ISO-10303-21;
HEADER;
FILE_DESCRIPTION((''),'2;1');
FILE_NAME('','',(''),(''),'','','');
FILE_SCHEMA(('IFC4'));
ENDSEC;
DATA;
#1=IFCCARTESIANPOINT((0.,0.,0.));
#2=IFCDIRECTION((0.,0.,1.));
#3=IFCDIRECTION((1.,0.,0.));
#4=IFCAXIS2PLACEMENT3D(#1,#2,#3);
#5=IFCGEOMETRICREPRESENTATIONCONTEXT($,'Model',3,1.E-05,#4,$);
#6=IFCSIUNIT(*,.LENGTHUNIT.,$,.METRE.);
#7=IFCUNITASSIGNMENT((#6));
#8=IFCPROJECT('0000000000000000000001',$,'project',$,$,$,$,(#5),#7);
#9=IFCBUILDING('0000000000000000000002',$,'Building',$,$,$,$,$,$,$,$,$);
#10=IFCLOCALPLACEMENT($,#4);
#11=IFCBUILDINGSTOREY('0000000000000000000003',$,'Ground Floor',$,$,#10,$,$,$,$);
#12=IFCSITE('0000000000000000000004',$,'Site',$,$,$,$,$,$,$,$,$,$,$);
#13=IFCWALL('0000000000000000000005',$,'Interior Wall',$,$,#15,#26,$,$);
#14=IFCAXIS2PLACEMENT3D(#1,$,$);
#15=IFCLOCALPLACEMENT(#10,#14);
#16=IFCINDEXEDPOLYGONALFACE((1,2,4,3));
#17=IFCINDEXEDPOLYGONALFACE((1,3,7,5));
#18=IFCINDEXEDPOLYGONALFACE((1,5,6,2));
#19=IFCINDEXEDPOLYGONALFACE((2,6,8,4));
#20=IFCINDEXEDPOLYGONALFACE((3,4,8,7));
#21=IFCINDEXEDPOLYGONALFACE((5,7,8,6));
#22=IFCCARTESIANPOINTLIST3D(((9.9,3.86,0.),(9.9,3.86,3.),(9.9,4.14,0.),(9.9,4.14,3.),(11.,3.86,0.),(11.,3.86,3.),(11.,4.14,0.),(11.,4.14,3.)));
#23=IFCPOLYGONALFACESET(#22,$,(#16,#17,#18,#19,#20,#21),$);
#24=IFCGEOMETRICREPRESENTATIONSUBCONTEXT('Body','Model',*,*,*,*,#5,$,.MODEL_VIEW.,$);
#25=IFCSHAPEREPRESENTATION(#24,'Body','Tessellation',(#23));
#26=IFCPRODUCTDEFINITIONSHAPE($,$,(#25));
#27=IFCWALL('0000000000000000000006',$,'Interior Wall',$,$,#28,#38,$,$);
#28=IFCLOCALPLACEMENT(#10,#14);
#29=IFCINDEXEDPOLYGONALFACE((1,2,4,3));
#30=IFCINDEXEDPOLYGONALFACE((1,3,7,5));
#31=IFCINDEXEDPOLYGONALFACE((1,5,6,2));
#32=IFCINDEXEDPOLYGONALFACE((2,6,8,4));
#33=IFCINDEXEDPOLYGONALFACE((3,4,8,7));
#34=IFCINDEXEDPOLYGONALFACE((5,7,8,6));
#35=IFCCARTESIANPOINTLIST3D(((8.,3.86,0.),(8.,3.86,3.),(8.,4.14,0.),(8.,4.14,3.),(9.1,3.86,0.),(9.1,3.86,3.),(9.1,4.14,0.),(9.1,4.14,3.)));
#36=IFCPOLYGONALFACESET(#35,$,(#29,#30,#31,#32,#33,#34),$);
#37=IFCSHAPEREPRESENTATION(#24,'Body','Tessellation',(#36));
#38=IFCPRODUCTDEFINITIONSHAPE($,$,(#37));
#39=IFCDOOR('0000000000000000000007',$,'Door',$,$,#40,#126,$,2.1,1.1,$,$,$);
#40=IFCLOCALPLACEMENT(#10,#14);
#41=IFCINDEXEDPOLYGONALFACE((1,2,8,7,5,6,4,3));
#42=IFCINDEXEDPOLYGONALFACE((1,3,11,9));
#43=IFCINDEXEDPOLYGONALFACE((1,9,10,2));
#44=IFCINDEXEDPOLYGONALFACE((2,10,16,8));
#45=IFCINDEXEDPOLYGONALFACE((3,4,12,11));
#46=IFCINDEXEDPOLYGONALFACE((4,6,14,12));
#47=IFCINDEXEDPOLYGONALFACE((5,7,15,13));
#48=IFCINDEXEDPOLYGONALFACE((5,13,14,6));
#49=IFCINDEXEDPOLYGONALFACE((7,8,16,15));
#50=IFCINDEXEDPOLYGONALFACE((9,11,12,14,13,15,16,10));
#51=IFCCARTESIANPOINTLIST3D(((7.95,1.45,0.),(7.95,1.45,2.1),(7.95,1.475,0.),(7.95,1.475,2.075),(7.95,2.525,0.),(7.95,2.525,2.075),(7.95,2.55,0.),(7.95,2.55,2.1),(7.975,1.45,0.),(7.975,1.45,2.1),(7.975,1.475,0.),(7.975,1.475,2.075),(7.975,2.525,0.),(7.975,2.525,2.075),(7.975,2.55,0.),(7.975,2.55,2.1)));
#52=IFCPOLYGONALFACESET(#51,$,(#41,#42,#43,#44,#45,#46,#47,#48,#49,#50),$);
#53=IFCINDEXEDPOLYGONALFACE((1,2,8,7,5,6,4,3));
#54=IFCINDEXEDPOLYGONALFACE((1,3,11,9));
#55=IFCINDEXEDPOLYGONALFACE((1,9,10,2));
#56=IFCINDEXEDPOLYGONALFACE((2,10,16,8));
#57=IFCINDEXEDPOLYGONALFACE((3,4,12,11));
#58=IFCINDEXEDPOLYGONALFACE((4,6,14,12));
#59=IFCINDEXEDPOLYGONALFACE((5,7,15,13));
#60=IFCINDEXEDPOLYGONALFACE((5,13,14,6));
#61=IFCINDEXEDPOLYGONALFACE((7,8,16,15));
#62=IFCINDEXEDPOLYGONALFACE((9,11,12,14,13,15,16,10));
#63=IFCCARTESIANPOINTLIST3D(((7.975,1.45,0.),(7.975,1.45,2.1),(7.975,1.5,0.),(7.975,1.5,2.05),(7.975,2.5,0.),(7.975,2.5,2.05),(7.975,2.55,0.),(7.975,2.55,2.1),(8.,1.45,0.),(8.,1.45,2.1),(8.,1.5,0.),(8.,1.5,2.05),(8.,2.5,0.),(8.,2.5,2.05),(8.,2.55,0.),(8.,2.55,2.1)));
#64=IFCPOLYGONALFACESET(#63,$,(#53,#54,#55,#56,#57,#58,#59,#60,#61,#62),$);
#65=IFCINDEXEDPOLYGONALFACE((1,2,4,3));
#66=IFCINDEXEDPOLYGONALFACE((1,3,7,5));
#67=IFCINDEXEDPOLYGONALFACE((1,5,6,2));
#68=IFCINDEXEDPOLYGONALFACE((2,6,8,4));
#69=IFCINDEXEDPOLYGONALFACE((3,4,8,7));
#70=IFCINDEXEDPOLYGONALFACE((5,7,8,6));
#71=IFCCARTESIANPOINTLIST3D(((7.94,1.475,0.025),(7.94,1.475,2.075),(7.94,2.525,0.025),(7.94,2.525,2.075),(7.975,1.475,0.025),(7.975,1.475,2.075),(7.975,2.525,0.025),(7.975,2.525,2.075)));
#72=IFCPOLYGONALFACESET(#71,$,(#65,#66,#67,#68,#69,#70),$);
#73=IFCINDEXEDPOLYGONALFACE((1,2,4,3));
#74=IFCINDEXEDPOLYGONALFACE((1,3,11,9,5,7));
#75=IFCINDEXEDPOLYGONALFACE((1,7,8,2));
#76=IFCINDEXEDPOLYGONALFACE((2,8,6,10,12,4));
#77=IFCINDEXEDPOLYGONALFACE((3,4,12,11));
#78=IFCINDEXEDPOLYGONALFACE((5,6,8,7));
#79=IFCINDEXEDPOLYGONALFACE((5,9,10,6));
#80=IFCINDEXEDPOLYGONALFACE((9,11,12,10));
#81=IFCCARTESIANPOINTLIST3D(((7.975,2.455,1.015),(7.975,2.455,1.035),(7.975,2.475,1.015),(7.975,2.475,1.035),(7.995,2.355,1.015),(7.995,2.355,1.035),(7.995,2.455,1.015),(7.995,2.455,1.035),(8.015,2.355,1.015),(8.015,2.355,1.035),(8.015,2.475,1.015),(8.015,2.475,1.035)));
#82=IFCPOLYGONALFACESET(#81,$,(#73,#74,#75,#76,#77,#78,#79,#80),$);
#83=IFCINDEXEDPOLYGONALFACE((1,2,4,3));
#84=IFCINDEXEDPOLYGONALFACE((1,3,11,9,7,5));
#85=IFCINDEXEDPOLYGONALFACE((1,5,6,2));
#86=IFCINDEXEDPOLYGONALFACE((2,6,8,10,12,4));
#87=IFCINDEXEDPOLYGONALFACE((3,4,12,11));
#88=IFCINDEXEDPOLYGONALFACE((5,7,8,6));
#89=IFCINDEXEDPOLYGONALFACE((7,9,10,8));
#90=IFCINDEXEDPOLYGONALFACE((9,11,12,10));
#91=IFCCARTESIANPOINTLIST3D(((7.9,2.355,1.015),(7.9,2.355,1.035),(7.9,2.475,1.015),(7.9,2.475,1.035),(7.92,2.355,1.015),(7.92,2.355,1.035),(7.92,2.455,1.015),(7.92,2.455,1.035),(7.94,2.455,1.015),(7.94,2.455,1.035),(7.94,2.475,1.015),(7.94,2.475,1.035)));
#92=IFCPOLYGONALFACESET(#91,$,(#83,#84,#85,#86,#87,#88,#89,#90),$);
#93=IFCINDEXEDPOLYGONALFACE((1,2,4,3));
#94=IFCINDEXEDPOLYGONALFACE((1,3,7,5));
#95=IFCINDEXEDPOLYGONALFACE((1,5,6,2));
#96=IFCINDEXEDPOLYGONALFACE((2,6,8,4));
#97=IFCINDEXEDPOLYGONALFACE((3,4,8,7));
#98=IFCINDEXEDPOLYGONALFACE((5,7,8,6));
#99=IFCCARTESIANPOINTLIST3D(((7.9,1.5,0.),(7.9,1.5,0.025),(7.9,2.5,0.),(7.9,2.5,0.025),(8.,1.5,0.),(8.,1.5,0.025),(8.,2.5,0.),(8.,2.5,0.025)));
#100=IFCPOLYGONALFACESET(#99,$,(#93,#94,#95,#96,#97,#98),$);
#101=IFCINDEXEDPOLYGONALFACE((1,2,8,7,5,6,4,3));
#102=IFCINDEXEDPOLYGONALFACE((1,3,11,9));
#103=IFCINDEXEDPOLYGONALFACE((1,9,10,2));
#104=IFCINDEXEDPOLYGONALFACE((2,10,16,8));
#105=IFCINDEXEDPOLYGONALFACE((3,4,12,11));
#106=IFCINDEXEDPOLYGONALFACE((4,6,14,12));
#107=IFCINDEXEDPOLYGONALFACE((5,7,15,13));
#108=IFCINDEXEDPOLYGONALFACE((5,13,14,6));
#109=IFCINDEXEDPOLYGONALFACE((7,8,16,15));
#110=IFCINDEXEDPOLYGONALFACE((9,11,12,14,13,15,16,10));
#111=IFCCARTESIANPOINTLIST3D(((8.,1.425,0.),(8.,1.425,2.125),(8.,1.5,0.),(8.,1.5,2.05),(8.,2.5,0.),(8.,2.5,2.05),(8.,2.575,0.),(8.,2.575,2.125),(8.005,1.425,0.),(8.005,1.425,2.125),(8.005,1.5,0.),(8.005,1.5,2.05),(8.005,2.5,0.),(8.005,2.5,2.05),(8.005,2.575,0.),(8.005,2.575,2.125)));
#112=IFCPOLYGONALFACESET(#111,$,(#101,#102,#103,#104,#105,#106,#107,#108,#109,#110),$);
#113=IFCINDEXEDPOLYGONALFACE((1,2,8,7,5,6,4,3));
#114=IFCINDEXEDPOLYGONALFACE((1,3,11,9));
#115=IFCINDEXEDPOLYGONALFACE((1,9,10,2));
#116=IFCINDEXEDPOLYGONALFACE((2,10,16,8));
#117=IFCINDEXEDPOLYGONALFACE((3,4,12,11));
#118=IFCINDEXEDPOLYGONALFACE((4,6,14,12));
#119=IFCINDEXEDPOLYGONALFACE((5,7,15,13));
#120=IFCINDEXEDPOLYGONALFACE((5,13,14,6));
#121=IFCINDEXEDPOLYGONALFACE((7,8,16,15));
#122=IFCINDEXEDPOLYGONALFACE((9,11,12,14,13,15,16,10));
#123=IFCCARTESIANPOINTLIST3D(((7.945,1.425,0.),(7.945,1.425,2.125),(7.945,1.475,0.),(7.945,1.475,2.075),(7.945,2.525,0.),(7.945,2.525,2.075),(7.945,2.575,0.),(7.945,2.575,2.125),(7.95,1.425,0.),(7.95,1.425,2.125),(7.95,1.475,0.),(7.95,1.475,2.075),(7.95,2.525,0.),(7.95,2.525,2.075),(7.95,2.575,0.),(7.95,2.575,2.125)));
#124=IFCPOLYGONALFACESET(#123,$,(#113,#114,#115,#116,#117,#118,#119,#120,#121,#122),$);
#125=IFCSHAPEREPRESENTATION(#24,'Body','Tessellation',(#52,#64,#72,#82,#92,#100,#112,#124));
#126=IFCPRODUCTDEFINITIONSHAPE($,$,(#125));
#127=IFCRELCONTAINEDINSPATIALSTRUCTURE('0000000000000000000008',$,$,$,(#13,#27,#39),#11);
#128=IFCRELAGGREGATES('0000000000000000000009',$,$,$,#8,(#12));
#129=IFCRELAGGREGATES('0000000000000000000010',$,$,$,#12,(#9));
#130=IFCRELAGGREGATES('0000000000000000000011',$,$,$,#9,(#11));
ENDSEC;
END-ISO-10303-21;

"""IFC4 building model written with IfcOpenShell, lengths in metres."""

from ifc_helpers import new_model, si_unit, frame, origin_with_axes, place, context, subcontext, project, spatial, line, indexed_curve, outline, extrude, element, save


model = new_model("IFC4")

# Units and contexts
model_context = context("Model", 3, precision=1e-05, world=origin_with_axes())
body_context = subcontext(model_context, "Body", "Model", "MODEL_VIEW")
ifc_project = project(units=[si_unit("LENGTHUNIT", "METRE")], contexts=[model_context])

# Site, building, storey
site = spatial("IfcSite", under=ifc_project, Name="Site")
building = spatial("IfcBuilding", under=site, Name="Building")
storey_placement = place(None, origin_with_axes())
storey = spatial("IfcBuildingStorey", under=building, at=storey_placement, Name="Ground Floor")

# Walls
for number, where, z_axis, x_axis, name in (
    (1, (11.0, 4.0, 0.0), (0.0, 0.0, 1.0), (-1.0, 0.0, 0.0), "Interior Wall"),
    (2, (9.1, 4.0, 0.0), (0.0, 0.0, 1.0), (-1.0, 0.0, 0.0), "Interior Wall"),
):
    element("IfcWall", number, at=place(storey_placement, frame(where, z_axis=z_axis, x_axis=x_axis)), inside=storey, Name=name, context=body_context, shape_type="SweptSolid", body=[
        extrude(outline(indexed_curve([(0.0, 0.0), (0.0, 0.28), (1.1, 0.28), (1.1, 0.0), (0.0, 0.0)], self_intersect=False)), frame((0.0, -0.14, 0.0), z_axis=(0.0, 0.0, 1.0), x_axis=(1.0, 0.0, 0.0)), (0.0, 0.0, 1.0), 3.0),
    ])

# Door
door_1_placement = place(storey_placement, frame((8.0, 1.45, 0.0), z_axis=(0.0, 0.0, 1.0), x_axis=(0.0, 1.0, 0.0)))
element("IfcDoor", 3, at=door_1_placement, inside=storey, Name="Door", OverallHeight=2.1, OverallWidth=1.1, context=body_context, shape_type="SweptSolid", body=[
    extrude(outline(indexed_curve([(0.0, 0.0), (0.0, 2.1), (1.1, 2.1), (1.1, 0.0), (1.075, 0.0), (1.075, 2.075), (0.025, 2.075), (0.025, 0.0)], segments=[line(1, 2, 3, 4, 5, 6, 7, 8, 1)])), frame((0.0, 0.025, 0.0), z_axis=(0.0, -1.0, 0.0), x_axis=(1.0, 0.0, 0.0)), (0.0, 0.0, -1.0), 0.025),
    extrude(outline(indexed_curve([(0.0, 0.0), (0.0, 2.1), (1.1, 2.1), (1.1, 0.0), (1.05, 0.0), (1.05, 2.05), (0.05, 2.05), (0.05, 0.0)], segments=[line(1, 2, 3, 4, 5, 6, 7, 8, 1)])), frame((0.0, 0.0, 0.0), z_axis=(0.0, -1.0, 0.0), x_axis=(1.0, 0.0, 0.0)), (0.0, 0.0, -1.0), 0.025),
    extrude(outline(indexed_curve([(0.0, 0.0), (1.05, 0.0), (1.05, 0.035), (0.0, 0.035)], segments=[line(1, 2, 3, 4, 1)])), frame((0.025, 0.025, 0.025), z_axis=(0.0, 0.0, 1.0), x_axis=(1.0, 0.0, 0.0)), (0.0, 0.0, 1.0), 2.05),
    extrude(outline(indexed_curve([(0.0, 0.0), (0.0, -0.04), (-0.12, -0.04), (-0.12, -0.02), (-0.02, -0.02), (-0.02, 0.0)], segments=[line(1, 2, 3, 4, 5, 6, 1)])), frame((1.025, 0.025, 1.015), z_axis=(0.0, 0.0, 1.0), x_axis=(1.0, 0.0, 0.0)), (0.0, 0.0, 1.0), 0.02),
    extrude(outline(indexed_curve([(0.0, 0.0), (0.0, 0.04), (-0.12, 0.04), (-0.12, 0.02), (-0.02, 0.02), (-0.02, 0.0)], segments=[line(1, 2, 3, 4, 5, 6, 1)])), frame((1.025, 0.06, 1.015), z_axis=(0.0, 0.0, 1.0), x_axis=(1.0, 0.0, 0.0)), (0.0, 0.0, 1.0), 0.02),
    extrude(outline(indexed_curve([(0.0, 0.0), (1.0, 0.0), (1.0, 0.1), (0.0, 0.1)], segments=[line(1, 2, 3, 4, 1)])), frame((0.05, 0.0, 0.0), z_axis=(0.0, 0.0, 1.0), x_axis=(1.0, 0.0, 0.0)), (0.0, 0.0, 1.0), 0.025),
    extrude(outline(indexed_curve([(0.0, 0.0), (0.0, 2.125), (1.15, 2.125), (1.15, 0.0), (1.075, 0.0), (1.075, 2.05), (0.075, 2.05), (0.075, 0.0)], segments=[line(1, 2, 3, 4, 5, 6, 7, 8, 1)])), frame((-0.025, -0.005, 0.0), z_axis=(0.0, -1.0, 0.0), x_axis=(1.0, 0.0, 0.0)), (0.0, 0.0, -1.0), 0.005),
    extrude(outline(indexed_curve([(0.0, 0.0), (0.0, 2.125), (1.15, 2.125), (1.15, 0.0), (1.1, 0.0), (1.1, 2.075), (0.05, 2.075), (0.05, 0.0)], segments=[line(1, 2, 3, 4, 5, 6, 7, 8, 1)])), frame((-0.025, 0.05, 0.0), z_axis=(0.0, -1.0, 0.0), x_axis=(1.0, 0.0, 0.0)), (0.0, 0.0, -1.0), 0.005),
])

save(model, "model.ifc")
